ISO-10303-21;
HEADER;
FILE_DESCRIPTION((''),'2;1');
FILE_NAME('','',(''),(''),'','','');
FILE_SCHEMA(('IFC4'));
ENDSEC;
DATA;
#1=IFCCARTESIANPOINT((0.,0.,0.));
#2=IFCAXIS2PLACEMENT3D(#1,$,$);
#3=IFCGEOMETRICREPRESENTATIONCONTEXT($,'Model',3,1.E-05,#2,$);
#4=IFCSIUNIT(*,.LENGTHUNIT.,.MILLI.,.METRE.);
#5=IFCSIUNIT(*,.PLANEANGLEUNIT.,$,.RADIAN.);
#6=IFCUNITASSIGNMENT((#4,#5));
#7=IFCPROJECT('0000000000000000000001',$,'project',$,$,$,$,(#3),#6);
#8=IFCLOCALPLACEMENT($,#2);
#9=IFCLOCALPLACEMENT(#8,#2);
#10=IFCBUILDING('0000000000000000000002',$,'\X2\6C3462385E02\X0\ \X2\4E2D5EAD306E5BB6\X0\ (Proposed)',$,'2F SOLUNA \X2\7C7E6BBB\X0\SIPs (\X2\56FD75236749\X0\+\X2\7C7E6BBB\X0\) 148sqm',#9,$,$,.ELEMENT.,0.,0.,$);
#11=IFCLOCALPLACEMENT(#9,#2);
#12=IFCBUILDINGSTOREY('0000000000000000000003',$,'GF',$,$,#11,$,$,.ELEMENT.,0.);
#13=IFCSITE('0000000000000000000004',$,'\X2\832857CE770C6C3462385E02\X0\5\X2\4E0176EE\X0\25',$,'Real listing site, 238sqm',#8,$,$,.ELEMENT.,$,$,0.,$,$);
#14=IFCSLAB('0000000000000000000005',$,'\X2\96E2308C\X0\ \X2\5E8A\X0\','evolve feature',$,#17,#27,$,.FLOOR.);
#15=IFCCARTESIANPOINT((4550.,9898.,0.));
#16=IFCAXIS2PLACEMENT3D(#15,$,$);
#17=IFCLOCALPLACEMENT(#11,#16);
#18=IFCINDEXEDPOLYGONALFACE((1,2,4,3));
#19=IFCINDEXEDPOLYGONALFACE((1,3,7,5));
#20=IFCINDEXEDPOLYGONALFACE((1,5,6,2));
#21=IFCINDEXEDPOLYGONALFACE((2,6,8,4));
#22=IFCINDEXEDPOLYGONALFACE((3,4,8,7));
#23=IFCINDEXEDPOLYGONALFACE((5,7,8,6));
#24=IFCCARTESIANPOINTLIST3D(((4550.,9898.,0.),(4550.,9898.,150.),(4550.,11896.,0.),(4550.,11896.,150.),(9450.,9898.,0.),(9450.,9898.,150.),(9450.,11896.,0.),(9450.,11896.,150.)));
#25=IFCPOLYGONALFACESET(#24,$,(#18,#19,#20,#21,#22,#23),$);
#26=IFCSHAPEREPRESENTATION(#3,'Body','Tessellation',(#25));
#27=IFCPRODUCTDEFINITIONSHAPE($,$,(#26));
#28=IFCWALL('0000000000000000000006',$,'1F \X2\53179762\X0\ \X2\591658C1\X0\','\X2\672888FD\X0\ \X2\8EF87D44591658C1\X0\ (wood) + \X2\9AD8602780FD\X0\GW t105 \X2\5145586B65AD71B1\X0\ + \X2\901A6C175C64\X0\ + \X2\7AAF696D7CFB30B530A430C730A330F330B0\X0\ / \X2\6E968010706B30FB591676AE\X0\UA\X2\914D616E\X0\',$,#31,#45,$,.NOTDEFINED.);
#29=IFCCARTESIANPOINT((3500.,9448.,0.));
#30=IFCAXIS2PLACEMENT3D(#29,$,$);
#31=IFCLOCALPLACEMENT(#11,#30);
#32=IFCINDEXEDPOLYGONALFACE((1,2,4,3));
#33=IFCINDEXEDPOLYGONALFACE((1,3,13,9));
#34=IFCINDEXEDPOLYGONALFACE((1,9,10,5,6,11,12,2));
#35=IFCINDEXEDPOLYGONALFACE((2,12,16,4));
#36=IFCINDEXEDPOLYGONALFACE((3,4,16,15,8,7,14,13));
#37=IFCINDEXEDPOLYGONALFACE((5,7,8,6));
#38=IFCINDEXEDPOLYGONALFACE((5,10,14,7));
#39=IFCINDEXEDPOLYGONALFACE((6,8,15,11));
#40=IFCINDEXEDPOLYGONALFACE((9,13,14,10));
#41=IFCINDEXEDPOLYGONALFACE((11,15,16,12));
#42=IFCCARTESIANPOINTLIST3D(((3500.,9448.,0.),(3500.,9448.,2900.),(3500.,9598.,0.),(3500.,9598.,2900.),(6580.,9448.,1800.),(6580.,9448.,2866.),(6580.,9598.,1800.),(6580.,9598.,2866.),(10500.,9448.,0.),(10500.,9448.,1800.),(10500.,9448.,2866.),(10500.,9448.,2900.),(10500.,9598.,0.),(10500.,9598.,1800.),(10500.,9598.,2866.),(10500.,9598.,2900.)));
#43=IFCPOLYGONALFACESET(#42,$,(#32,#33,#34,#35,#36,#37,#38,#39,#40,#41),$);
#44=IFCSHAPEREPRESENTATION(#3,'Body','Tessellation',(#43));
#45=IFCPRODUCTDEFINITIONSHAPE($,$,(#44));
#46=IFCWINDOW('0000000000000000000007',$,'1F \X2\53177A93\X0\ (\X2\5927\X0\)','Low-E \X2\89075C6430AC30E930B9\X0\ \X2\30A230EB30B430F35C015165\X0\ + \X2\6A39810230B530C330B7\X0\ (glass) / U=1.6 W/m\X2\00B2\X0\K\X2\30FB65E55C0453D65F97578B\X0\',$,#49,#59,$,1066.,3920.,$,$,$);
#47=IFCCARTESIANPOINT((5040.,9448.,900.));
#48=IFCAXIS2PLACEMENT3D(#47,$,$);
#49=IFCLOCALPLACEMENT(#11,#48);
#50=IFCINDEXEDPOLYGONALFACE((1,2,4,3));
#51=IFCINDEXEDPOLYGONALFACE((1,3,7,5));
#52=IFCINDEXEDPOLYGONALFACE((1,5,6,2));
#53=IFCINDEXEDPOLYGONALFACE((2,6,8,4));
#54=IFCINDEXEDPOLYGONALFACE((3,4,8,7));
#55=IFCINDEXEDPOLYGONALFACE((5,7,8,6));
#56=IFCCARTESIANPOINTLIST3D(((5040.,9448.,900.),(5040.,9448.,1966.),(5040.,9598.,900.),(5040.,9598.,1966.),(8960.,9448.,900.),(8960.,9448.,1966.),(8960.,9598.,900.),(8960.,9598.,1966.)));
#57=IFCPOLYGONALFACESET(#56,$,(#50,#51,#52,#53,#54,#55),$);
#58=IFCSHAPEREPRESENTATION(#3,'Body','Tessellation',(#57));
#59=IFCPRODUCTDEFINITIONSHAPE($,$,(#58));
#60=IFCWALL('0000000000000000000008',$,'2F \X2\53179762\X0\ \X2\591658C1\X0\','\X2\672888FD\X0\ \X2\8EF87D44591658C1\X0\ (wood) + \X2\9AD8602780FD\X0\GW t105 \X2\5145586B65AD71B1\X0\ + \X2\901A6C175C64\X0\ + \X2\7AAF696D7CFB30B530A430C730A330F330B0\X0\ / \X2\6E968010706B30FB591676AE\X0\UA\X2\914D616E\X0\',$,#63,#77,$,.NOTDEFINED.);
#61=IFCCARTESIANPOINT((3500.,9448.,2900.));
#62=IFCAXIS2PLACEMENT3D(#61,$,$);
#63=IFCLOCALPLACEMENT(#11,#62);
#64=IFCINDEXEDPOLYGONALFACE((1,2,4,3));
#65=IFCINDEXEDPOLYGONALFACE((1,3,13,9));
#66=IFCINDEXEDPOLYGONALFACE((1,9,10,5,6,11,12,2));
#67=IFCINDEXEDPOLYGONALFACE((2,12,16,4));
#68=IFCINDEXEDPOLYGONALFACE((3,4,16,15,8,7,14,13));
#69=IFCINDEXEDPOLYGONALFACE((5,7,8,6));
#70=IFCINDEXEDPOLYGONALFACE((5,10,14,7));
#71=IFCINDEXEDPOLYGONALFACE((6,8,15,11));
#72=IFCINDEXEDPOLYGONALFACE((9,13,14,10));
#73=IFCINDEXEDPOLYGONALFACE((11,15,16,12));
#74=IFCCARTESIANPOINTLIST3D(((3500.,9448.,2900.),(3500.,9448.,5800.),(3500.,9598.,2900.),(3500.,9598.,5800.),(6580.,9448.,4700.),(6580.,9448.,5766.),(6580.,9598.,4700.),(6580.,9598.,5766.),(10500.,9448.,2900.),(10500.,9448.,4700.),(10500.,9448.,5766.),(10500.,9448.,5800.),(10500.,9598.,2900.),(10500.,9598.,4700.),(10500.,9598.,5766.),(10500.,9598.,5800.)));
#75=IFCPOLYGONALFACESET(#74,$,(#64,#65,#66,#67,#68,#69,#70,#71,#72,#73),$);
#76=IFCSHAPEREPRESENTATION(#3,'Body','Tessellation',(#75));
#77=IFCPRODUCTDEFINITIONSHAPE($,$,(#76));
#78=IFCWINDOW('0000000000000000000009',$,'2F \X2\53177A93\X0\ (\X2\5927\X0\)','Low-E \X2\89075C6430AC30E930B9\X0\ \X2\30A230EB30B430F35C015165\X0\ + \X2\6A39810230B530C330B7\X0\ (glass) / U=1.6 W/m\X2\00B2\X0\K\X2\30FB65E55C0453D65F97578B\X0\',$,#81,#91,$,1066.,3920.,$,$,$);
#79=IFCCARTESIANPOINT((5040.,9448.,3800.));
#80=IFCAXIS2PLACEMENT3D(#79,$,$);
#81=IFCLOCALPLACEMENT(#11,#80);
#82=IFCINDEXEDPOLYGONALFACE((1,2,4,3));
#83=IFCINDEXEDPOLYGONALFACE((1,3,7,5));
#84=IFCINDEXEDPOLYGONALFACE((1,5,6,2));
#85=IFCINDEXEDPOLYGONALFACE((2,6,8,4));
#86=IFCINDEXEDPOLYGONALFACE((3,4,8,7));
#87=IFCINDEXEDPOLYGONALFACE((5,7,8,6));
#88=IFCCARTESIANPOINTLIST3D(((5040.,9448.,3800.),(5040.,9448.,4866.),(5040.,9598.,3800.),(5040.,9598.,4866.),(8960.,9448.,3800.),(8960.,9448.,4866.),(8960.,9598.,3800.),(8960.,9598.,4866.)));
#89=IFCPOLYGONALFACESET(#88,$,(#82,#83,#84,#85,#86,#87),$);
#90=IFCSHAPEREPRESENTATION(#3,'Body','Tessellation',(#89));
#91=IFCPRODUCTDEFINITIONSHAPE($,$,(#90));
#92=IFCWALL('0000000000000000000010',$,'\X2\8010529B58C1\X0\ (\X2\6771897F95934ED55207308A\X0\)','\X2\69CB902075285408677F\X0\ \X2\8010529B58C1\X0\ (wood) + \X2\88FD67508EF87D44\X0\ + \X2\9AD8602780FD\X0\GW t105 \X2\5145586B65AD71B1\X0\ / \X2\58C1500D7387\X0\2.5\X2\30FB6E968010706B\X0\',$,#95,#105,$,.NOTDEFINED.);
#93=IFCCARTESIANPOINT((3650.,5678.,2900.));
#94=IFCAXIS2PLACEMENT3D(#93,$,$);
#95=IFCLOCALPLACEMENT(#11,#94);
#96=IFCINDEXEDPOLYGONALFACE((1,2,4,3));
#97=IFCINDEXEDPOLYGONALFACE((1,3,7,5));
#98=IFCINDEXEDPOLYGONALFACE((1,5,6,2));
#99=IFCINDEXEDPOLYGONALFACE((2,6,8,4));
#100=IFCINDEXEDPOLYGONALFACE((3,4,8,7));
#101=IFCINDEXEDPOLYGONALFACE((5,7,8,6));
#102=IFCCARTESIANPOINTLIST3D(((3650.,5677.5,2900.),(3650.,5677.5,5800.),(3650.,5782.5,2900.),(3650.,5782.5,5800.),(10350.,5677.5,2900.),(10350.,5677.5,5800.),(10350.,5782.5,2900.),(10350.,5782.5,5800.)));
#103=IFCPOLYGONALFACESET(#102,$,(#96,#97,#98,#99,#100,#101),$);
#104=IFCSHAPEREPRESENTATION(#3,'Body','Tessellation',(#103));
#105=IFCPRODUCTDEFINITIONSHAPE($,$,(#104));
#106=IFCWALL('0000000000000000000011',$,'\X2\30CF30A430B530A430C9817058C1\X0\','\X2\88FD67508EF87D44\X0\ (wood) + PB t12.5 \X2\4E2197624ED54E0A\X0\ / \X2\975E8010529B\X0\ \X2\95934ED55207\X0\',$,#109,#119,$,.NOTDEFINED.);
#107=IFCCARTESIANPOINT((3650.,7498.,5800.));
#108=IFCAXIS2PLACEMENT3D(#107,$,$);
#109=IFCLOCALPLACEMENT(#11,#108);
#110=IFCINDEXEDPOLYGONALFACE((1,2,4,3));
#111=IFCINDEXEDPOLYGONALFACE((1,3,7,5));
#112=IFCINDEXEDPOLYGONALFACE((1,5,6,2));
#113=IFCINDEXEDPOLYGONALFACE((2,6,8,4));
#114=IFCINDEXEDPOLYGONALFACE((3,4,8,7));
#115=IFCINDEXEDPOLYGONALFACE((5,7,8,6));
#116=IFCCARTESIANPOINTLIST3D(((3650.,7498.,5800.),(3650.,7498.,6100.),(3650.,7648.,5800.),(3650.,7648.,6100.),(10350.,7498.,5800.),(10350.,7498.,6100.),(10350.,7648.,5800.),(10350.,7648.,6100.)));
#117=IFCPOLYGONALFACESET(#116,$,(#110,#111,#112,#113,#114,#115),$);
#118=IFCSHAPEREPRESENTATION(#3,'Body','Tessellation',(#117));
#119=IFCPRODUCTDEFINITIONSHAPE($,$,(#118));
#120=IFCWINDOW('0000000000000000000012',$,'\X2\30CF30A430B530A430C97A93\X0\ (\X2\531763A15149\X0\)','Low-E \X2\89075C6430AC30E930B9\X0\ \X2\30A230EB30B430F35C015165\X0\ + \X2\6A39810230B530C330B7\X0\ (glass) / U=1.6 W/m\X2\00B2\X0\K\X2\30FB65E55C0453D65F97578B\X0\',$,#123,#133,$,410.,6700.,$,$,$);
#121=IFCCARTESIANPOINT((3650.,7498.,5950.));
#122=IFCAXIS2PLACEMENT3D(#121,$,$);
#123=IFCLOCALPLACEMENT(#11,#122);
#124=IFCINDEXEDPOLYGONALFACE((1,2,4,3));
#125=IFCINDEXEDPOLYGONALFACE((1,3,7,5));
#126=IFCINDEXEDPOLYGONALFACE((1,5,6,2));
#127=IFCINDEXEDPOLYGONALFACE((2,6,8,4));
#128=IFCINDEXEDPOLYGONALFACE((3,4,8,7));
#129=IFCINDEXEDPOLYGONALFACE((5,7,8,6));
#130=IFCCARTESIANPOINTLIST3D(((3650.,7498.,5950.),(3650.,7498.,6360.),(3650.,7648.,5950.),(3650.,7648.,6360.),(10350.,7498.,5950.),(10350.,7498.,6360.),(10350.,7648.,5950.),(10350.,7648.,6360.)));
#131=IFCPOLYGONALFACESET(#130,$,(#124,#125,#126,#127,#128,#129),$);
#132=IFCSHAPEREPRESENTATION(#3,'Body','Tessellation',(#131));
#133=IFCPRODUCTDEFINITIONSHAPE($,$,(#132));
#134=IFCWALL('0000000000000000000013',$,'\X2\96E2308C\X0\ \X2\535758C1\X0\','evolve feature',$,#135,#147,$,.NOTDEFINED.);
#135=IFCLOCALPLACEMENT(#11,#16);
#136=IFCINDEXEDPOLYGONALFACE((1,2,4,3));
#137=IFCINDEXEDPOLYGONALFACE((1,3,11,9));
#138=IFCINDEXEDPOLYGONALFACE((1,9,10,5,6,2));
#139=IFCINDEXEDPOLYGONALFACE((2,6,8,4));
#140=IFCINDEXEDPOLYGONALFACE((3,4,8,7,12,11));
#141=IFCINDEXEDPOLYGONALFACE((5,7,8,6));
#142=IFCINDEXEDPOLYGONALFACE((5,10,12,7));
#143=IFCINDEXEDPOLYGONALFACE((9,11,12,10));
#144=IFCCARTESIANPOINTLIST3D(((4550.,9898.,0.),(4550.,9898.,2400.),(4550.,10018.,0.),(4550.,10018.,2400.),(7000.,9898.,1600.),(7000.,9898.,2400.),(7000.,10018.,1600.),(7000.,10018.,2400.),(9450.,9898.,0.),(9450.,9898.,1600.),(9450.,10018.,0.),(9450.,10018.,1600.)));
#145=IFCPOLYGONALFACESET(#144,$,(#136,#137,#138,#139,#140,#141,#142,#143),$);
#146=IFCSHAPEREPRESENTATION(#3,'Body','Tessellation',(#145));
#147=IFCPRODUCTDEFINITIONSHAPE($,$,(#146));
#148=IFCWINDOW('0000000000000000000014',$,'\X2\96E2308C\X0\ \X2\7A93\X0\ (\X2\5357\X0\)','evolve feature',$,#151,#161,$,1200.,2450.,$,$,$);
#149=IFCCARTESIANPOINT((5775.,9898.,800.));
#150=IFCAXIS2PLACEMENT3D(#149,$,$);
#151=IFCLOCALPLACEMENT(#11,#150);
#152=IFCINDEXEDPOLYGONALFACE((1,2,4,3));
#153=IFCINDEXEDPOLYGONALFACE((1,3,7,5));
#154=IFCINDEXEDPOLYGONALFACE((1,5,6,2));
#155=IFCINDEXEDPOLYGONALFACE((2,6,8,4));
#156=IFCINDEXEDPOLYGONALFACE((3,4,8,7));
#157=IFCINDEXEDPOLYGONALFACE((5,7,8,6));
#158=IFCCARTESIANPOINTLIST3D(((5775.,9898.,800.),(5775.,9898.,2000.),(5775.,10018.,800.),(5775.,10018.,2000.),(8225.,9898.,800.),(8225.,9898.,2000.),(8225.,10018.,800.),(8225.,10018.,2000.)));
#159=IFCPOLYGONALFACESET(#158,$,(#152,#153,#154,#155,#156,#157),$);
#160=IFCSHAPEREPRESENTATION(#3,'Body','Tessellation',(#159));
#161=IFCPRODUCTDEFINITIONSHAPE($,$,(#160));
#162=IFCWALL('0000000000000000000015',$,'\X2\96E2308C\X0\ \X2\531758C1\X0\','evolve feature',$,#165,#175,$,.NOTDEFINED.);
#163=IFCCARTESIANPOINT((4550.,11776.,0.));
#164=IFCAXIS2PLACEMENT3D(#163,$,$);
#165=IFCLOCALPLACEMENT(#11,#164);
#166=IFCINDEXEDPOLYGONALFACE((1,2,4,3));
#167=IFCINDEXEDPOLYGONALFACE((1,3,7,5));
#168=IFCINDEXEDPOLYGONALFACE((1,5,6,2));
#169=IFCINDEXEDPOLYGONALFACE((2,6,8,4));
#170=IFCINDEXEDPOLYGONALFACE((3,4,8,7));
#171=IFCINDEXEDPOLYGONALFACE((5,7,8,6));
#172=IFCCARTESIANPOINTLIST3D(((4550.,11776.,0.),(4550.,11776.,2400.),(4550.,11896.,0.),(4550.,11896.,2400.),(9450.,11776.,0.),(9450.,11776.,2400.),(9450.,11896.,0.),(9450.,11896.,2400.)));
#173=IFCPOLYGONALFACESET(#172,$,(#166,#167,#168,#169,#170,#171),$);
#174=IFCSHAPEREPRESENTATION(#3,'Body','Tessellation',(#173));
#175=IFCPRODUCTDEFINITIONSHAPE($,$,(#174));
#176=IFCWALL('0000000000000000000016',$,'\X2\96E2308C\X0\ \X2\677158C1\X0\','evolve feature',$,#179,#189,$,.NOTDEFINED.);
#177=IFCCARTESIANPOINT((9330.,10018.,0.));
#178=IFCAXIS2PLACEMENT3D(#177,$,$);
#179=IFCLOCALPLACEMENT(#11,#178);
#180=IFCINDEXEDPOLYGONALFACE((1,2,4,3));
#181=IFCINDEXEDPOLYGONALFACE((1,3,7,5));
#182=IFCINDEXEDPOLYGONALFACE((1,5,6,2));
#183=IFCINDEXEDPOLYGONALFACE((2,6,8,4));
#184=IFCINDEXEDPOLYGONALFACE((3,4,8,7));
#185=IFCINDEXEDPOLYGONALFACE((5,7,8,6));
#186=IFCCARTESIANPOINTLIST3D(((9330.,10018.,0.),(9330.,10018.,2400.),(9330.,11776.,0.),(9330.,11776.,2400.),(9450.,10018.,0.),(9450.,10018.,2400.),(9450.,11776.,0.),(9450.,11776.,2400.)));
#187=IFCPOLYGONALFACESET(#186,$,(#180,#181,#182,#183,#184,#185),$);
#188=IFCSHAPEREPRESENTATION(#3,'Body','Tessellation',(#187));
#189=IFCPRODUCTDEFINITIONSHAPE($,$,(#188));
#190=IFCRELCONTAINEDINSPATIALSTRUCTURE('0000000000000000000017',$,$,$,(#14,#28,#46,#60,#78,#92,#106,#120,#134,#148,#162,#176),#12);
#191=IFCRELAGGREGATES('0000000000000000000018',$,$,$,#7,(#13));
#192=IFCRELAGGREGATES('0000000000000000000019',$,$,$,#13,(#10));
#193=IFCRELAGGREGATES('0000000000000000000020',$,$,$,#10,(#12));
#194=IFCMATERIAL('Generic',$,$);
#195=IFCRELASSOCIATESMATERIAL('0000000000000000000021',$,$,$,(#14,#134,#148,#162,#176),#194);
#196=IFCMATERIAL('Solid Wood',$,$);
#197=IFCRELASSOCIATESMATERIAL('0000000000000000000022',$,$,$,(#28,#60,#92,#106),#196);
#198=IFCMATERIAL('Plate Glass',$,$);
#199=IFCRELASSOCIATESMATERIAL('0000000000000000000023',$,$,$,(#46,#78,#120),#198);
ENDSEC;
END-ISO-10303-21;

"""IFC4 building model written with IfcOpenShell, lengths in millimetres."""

from ifc_helpers import new_model, si_unit, frame, frame_2d, origin, place, context, project, spatial, rectangle, extrude, material, element, fill, save


model = new_model("IFC4")

# Units and contexts
model_context = context("Model", 3, precision=1e-05, world=origin())
ifc_project = project(units=[si_unit("LENGTHUNIT", "METRE", prefix="MILLI"), si_unit("PLANEANGLEUNIT", "RADIAN")], contexts=[model_context])

# Site, building, storey
site_placement = place(None, origin())
site = spatial("IfcSite", under=ifc_project, at=site_placement, Name="茨城県水戸市5丁目25", ObjectType="Real listing site, 238sqm", CompositionType="ELEMENT", RefElevation=0.0)
building_placement = place(site_placement, origin())
building = spatial("IfcBuilding", under=site, at=building_placement, Name="水戸市 中庭の家 (Proposed)", ObjectType="2F SOLUNA 籾殻SIPs (国産杉+籾殻) 148sqm", CompositionType="ELEMENT", ElevationOfRefHeight=0.0, ElevationOfTerrain=0.0)
storey_placement = place(building_placement, origin())
storey = spatial("IfcBuildingStorey", under=building, at=storey_placement, Name="GF", CompositionType="ELEMENT", Elevation=0.0)

# Slab
ifc_material_1 = material(Name="Generic")
slab_placement = place(storey_placement, frame((4550.0, 9898.0, 0.0)))
element("IfcSlab", 1, at=slab_placement, inside=storey, material=ifc_material_1, Name="離れ 床", Description="evolve feature", PredefinedType="FLOOR", context=model_context, shape_type="SweptSolid", body=[
    extrude(rectangle(XDim=4900.0, YDim=1998.0, at=frame_2d((2450.0, 999.0))), frame((4550.0, 9898.0, 0.0)), (0.0, 0.0, 1.0), 150.0),
])

# Wall, opening, window
ifc_material_2 = material(Name="Solid Wood")
wall_1_placement = place(storey_placement, frame((3500.0, 9448.0, 0.0)))
wall_1 = element("IfcWall", 2, at=wall_1_placement, inside=storey, material=ifc_material_2, Name="1F 北面 外壁", Description="木製 軸組外壁 (wood) + 高性能GW t105 充填断熱 + 通気層 + 窯業系サイディング / 準耐火・外皮UA配慮", PredefinedType="NOTDEFINED", context=model_context, shape_type="SweptSolid", body=[
    extrude(rectangle(XDim=7000.0, YDim=150.0, at=frame_2d((3500.0, 75.0))), frame((3500.0, 9448.0, 0.0)), (0.0, 0.0, 1.0), 2900.0),
])
opening_1_placement = place(storey_placement, frame((5040.0, 9448.0, 900.0)))
opening_1 = element("IfcOpeningElement", 3, at=opening_1_placement, cuts=wall_1, PredefinedType="NOTDEFINED", context=model_context, shape_type="SweptSolid", body=[
    extrude(rectangle(XDim=3920.0, YDim=150.0, at=frame_2d((1960.0, 75.0))), frame((5040.0, 9448.0, 900.0)), (0.0, 0.0, 1.0), 1066.0),
])
ifc_material_3 = material(Name="Plate Glass")
window_1_placement = place(storey_placement, frame((5040.0, 9448.0, 900.0)))
window_1 = element("IfcWindow", 4, at=window_1_placement, inside=storey, material=ifc_material_3, Name="1F 北窓 (大)", Description="Low-E 複層ガラス アルゴン封入 + 樹脂サッシ (glass) / U=1.6 W/m²K・日射取得型", OverallHeight=1066.0, OverallWidth=3920.0, context=model_context, shape_type="SweptSolid", body=[
    extrude(rectangle(XDim=3920.0, YDim=150.0, at=frame_2d((1960.0, 75.0))), frame((5040.0, 9448.0, 900.0)), (0.0, 0.0, 1.0), 1066.0),
])
fill(opening_1, window_1)

# Wall, opening, window
wall_2_placement = place(storey_placement, frame((3500.0, 9448.0, 2900.0)))
wall_2 = element("IfcWall", 5, at=wall_2_placement, inside=storey, material=ifc_material_2, Name="2F 北面 外壁", Description="木製 軸組外壁 (wood) + 高性能GW t105 充填断熱 + 通気層 + 窯業系サイディング / 準耐火・外皮UA配慮", PredefinedType="NOTDEFINED", context=model_context, shape_type="SweptSolid", body=[
    extrude(rectangle(XDim=7000.0, YDim=150.0, at=frame_2d((3500.0, 75.0))), frame((3500.0, 9448.0, 2900.0)), (0.0, 0.0, 1.0), 2900.0),
])
opening_2_placement = place(storey_placement, frame((5040.0, 9448.0, 3800.0)))
opening_2 = element("IfcOpeningElement", 6, at=opening_2_placement, cuts=wall_2, PredefinedType="NOTDEFINED", context=model_context, shape_type="SweptSolid", body=[
    extrude(rectangle(XDim=3920.0, YDim=150.0, at=frame_2d((1960.0, 75.0))), frame((5040.0, 9448.0, 3800.0)), (0.0, 0.0, 1.0), 1066.0),
])
window_2_placement = place(storey_placement, frame((5040.0, 9448.0, 3800.0)))
window_2 = element("IfcWindow", 7, at=window_2_placement, inside=storey, material=ifc_material_3, Name="2F 北窓 (大)", Description="Low-E 複層ガラス アルゴン封入 + 樹脂サッシ (glass) / U=1.6 W/m²K・日射取得型", OverallHeight=1066.0, OverallWidth=3920.0, context=model_context, shape_type="SweptSolid", body=[
    extrude(rectangle(XDim=3920.0, YDim=150.0, at=frame_2d((1960.0, 75.0))), frame((5040.0, 9448.0, 3800.0)), (0.0, 0.0, 1.0), 1066.0),
])
fill(opening_2, window_2)

# Wall
wall_3_placement = place(storey_placement, frame((3650.0, 5678.0, 2900.0)))
element("IfcWall", 8, at=wall_3_placement, inside=storey, material=ifc_material_2, Name="耐力壁 (東西間仕切り)", Description="構造用合板 耐力壁 (wood) + 製材軸組 + 高性能GW t105 充填断熱 / 壁倍率2.5・準耐火", PredefinedType="NOTDEFINED", context=model_context, shape_type="SweptSolid", body=[
    extrude(rectangle(XDim=6700.0, YDim=105.0, at=frame_2d((3350.0, 52.0))), frame((3650.0, 5678.0, 2900.0)), (0.0, 0.0, 1.0), 2900.0),
])

# Walls, openings, windows
wall_4_placement = place(storey_placement, frame((3650.0, 7498.0, 5800.0)))
wall_4 = element("IfcWall", 9, at=wall_4_placement, inside=storey, material=ifc_material_2, Name="ハイサイド腰壁", Description="製材軸組 (wood) + PB t12.5 両面仕上 / 非耐力 間仕切", PredefinedType="NOTDEFINED", context=model_context, shape_type="SweptSolid", body=[
    extrude(rectangle(XDim=6700.0, YDim=150.0, at=frame_2d((3350.0, 75.0))), frame((3650.0, 7498.0, 5800.0)), (0.0, 0.0, 1.0), 700.0),
])
opening_3_placement = place(storey_placement, frame((3650.0, 7498.0, 5950.0)))
opening_3 = element("IfcOpeningElement", 10, at=opening_3_placement, cuts=wall_4, PredefinedType="NOTDEFINED", context=model_context, shape_type="SweptSolid", body=[
    extrude(rectangle(XDim=6700.0, YDim=150.0, at=frame_2d((3350.0, 75.0))), frame((3650.0, 7498.0, 5950.0)), (0.0, 0.0, 1.0), 410.0),
])
window_3_placement = place(storey_placement, frame((3650.0, 7498.0, 5950.0)))
window_3 = element("IfcWindow", 11, at=window_3_placement, inside=storey, material=ifc_material_3, Name="ハイサイド窓 (北採光)", Description="Low-E 複層ガラス アルゴン封入 + 樹脂サッシ (glass) / U=1.6 W/m²K・日射取得型", OverallHeight=410.0, OverallWidth=6700.0, context=model_context, shape_type="SweptSolid", body=[
    extrude(rectangle(XDim=6700.0, YDim=150.0, at=frame_2d((3350.0, 75.0))), frame((3650.0, 7498.0, 5950.0)), (0.0, 0.0, 1.0), 410.0),
])
fill(opening_3, window_3)
wall_5_placement = place(storey_placement, frame((4550.0, 9898.0, 0.0)))
wall_5 = element("IfcWall", 12, at=wall_5_placement, inside=storey, material=ifc_material_1, Name="離れ 南壁", Description="evolve feature", PredefinedType="NOTDEFINED", context=model_context, shape_type="SweptSolid", body=[
    extrude(rectangle(XDim=4900.0, YDim=120.0, at=frame_2d((2450.0, 60.0))), frame((4550.0, 9898.0, 0.0)), (0.0, 0.0, 1.0), 2400.0),
])
opening_4_placement = place(storey_placement, frame((5775.0, 9898.0, 800.0)))
opening_4 = element("IfcOpeningElement", 13, at=opening_4_placement, cuts=wall_5, PredefinedType="NOTDEFINED", context=model_context, shape_type="SweptSolid", body=[
    extrude(rectangle(XDim=2450.0, YDim=120.0, at=frame_2d((1225.0, 60.0))), frame((5775.0, 9898.0, 800.0)), (0.0, 0.0, 1.0), 1200.0),
])
window_4_placement = place(storey_placement, frame((5775.0, 9898.0, 800.0)))
window_4 = element("IfcWindow", 14, at=window_4_placement, inside=storey, material=ifc_material_1, Name="離れ 窓 (南)", Description="evolve feature", OverallHeight=1200.0, OverallWidth=2450.0, context=model_context, shape_type="SweptSolid", body=[
    extrude(rectangle(XDim=2450.0, YDim=120.0, at=frame_2d((1225.0, 60.0))), frame((5775.0, 9898.0, 800.0)), (0.0, 0.0, 1.0), 1200.0),
])
fill(opening_4, window_4)

# Walls
wall_6_placement = place(storey_placement, frame((4550.0, 11776.0, 0.0)))
element("IfcWall", 15, at=wall_6_placement, inside=storey, material=ifc_material_1, Name="離れ 北壁", Description="evolve feature", PredefinedType="NOTDEFINED", context=model_context, shape_type="SweptSolid", body=[
    extrude(rectangle(XDim=4900.0, YDim=120.0, at=frame_2d((2450.0, 60.0))), frame((4550.0, 11776.0, 0.0)), (0.0, 0.0, 1.0), 2400.0),
])
wall_7_placement = place(storey_placement, frame((9330.0, 10018.0, 0.0)))
element("IfcWall", 16, at=wall_7_placement, inside=storey, material=ifc_material_1, Name="離れ 東壁", Description="evolve feature", PredefinedType="NOTDEFINED", context=model_context, shape_type="SweptSolid", body=[
    extrude(rectangle(XDim=120.0, YDim=1758.0, at=frame_2d((60.0, 879.0))), frame((9330.0, 10018.0, 0.0)), (0.0, 0.0, 1.0), 2400.0),
])

save(model, "model.ifc")
